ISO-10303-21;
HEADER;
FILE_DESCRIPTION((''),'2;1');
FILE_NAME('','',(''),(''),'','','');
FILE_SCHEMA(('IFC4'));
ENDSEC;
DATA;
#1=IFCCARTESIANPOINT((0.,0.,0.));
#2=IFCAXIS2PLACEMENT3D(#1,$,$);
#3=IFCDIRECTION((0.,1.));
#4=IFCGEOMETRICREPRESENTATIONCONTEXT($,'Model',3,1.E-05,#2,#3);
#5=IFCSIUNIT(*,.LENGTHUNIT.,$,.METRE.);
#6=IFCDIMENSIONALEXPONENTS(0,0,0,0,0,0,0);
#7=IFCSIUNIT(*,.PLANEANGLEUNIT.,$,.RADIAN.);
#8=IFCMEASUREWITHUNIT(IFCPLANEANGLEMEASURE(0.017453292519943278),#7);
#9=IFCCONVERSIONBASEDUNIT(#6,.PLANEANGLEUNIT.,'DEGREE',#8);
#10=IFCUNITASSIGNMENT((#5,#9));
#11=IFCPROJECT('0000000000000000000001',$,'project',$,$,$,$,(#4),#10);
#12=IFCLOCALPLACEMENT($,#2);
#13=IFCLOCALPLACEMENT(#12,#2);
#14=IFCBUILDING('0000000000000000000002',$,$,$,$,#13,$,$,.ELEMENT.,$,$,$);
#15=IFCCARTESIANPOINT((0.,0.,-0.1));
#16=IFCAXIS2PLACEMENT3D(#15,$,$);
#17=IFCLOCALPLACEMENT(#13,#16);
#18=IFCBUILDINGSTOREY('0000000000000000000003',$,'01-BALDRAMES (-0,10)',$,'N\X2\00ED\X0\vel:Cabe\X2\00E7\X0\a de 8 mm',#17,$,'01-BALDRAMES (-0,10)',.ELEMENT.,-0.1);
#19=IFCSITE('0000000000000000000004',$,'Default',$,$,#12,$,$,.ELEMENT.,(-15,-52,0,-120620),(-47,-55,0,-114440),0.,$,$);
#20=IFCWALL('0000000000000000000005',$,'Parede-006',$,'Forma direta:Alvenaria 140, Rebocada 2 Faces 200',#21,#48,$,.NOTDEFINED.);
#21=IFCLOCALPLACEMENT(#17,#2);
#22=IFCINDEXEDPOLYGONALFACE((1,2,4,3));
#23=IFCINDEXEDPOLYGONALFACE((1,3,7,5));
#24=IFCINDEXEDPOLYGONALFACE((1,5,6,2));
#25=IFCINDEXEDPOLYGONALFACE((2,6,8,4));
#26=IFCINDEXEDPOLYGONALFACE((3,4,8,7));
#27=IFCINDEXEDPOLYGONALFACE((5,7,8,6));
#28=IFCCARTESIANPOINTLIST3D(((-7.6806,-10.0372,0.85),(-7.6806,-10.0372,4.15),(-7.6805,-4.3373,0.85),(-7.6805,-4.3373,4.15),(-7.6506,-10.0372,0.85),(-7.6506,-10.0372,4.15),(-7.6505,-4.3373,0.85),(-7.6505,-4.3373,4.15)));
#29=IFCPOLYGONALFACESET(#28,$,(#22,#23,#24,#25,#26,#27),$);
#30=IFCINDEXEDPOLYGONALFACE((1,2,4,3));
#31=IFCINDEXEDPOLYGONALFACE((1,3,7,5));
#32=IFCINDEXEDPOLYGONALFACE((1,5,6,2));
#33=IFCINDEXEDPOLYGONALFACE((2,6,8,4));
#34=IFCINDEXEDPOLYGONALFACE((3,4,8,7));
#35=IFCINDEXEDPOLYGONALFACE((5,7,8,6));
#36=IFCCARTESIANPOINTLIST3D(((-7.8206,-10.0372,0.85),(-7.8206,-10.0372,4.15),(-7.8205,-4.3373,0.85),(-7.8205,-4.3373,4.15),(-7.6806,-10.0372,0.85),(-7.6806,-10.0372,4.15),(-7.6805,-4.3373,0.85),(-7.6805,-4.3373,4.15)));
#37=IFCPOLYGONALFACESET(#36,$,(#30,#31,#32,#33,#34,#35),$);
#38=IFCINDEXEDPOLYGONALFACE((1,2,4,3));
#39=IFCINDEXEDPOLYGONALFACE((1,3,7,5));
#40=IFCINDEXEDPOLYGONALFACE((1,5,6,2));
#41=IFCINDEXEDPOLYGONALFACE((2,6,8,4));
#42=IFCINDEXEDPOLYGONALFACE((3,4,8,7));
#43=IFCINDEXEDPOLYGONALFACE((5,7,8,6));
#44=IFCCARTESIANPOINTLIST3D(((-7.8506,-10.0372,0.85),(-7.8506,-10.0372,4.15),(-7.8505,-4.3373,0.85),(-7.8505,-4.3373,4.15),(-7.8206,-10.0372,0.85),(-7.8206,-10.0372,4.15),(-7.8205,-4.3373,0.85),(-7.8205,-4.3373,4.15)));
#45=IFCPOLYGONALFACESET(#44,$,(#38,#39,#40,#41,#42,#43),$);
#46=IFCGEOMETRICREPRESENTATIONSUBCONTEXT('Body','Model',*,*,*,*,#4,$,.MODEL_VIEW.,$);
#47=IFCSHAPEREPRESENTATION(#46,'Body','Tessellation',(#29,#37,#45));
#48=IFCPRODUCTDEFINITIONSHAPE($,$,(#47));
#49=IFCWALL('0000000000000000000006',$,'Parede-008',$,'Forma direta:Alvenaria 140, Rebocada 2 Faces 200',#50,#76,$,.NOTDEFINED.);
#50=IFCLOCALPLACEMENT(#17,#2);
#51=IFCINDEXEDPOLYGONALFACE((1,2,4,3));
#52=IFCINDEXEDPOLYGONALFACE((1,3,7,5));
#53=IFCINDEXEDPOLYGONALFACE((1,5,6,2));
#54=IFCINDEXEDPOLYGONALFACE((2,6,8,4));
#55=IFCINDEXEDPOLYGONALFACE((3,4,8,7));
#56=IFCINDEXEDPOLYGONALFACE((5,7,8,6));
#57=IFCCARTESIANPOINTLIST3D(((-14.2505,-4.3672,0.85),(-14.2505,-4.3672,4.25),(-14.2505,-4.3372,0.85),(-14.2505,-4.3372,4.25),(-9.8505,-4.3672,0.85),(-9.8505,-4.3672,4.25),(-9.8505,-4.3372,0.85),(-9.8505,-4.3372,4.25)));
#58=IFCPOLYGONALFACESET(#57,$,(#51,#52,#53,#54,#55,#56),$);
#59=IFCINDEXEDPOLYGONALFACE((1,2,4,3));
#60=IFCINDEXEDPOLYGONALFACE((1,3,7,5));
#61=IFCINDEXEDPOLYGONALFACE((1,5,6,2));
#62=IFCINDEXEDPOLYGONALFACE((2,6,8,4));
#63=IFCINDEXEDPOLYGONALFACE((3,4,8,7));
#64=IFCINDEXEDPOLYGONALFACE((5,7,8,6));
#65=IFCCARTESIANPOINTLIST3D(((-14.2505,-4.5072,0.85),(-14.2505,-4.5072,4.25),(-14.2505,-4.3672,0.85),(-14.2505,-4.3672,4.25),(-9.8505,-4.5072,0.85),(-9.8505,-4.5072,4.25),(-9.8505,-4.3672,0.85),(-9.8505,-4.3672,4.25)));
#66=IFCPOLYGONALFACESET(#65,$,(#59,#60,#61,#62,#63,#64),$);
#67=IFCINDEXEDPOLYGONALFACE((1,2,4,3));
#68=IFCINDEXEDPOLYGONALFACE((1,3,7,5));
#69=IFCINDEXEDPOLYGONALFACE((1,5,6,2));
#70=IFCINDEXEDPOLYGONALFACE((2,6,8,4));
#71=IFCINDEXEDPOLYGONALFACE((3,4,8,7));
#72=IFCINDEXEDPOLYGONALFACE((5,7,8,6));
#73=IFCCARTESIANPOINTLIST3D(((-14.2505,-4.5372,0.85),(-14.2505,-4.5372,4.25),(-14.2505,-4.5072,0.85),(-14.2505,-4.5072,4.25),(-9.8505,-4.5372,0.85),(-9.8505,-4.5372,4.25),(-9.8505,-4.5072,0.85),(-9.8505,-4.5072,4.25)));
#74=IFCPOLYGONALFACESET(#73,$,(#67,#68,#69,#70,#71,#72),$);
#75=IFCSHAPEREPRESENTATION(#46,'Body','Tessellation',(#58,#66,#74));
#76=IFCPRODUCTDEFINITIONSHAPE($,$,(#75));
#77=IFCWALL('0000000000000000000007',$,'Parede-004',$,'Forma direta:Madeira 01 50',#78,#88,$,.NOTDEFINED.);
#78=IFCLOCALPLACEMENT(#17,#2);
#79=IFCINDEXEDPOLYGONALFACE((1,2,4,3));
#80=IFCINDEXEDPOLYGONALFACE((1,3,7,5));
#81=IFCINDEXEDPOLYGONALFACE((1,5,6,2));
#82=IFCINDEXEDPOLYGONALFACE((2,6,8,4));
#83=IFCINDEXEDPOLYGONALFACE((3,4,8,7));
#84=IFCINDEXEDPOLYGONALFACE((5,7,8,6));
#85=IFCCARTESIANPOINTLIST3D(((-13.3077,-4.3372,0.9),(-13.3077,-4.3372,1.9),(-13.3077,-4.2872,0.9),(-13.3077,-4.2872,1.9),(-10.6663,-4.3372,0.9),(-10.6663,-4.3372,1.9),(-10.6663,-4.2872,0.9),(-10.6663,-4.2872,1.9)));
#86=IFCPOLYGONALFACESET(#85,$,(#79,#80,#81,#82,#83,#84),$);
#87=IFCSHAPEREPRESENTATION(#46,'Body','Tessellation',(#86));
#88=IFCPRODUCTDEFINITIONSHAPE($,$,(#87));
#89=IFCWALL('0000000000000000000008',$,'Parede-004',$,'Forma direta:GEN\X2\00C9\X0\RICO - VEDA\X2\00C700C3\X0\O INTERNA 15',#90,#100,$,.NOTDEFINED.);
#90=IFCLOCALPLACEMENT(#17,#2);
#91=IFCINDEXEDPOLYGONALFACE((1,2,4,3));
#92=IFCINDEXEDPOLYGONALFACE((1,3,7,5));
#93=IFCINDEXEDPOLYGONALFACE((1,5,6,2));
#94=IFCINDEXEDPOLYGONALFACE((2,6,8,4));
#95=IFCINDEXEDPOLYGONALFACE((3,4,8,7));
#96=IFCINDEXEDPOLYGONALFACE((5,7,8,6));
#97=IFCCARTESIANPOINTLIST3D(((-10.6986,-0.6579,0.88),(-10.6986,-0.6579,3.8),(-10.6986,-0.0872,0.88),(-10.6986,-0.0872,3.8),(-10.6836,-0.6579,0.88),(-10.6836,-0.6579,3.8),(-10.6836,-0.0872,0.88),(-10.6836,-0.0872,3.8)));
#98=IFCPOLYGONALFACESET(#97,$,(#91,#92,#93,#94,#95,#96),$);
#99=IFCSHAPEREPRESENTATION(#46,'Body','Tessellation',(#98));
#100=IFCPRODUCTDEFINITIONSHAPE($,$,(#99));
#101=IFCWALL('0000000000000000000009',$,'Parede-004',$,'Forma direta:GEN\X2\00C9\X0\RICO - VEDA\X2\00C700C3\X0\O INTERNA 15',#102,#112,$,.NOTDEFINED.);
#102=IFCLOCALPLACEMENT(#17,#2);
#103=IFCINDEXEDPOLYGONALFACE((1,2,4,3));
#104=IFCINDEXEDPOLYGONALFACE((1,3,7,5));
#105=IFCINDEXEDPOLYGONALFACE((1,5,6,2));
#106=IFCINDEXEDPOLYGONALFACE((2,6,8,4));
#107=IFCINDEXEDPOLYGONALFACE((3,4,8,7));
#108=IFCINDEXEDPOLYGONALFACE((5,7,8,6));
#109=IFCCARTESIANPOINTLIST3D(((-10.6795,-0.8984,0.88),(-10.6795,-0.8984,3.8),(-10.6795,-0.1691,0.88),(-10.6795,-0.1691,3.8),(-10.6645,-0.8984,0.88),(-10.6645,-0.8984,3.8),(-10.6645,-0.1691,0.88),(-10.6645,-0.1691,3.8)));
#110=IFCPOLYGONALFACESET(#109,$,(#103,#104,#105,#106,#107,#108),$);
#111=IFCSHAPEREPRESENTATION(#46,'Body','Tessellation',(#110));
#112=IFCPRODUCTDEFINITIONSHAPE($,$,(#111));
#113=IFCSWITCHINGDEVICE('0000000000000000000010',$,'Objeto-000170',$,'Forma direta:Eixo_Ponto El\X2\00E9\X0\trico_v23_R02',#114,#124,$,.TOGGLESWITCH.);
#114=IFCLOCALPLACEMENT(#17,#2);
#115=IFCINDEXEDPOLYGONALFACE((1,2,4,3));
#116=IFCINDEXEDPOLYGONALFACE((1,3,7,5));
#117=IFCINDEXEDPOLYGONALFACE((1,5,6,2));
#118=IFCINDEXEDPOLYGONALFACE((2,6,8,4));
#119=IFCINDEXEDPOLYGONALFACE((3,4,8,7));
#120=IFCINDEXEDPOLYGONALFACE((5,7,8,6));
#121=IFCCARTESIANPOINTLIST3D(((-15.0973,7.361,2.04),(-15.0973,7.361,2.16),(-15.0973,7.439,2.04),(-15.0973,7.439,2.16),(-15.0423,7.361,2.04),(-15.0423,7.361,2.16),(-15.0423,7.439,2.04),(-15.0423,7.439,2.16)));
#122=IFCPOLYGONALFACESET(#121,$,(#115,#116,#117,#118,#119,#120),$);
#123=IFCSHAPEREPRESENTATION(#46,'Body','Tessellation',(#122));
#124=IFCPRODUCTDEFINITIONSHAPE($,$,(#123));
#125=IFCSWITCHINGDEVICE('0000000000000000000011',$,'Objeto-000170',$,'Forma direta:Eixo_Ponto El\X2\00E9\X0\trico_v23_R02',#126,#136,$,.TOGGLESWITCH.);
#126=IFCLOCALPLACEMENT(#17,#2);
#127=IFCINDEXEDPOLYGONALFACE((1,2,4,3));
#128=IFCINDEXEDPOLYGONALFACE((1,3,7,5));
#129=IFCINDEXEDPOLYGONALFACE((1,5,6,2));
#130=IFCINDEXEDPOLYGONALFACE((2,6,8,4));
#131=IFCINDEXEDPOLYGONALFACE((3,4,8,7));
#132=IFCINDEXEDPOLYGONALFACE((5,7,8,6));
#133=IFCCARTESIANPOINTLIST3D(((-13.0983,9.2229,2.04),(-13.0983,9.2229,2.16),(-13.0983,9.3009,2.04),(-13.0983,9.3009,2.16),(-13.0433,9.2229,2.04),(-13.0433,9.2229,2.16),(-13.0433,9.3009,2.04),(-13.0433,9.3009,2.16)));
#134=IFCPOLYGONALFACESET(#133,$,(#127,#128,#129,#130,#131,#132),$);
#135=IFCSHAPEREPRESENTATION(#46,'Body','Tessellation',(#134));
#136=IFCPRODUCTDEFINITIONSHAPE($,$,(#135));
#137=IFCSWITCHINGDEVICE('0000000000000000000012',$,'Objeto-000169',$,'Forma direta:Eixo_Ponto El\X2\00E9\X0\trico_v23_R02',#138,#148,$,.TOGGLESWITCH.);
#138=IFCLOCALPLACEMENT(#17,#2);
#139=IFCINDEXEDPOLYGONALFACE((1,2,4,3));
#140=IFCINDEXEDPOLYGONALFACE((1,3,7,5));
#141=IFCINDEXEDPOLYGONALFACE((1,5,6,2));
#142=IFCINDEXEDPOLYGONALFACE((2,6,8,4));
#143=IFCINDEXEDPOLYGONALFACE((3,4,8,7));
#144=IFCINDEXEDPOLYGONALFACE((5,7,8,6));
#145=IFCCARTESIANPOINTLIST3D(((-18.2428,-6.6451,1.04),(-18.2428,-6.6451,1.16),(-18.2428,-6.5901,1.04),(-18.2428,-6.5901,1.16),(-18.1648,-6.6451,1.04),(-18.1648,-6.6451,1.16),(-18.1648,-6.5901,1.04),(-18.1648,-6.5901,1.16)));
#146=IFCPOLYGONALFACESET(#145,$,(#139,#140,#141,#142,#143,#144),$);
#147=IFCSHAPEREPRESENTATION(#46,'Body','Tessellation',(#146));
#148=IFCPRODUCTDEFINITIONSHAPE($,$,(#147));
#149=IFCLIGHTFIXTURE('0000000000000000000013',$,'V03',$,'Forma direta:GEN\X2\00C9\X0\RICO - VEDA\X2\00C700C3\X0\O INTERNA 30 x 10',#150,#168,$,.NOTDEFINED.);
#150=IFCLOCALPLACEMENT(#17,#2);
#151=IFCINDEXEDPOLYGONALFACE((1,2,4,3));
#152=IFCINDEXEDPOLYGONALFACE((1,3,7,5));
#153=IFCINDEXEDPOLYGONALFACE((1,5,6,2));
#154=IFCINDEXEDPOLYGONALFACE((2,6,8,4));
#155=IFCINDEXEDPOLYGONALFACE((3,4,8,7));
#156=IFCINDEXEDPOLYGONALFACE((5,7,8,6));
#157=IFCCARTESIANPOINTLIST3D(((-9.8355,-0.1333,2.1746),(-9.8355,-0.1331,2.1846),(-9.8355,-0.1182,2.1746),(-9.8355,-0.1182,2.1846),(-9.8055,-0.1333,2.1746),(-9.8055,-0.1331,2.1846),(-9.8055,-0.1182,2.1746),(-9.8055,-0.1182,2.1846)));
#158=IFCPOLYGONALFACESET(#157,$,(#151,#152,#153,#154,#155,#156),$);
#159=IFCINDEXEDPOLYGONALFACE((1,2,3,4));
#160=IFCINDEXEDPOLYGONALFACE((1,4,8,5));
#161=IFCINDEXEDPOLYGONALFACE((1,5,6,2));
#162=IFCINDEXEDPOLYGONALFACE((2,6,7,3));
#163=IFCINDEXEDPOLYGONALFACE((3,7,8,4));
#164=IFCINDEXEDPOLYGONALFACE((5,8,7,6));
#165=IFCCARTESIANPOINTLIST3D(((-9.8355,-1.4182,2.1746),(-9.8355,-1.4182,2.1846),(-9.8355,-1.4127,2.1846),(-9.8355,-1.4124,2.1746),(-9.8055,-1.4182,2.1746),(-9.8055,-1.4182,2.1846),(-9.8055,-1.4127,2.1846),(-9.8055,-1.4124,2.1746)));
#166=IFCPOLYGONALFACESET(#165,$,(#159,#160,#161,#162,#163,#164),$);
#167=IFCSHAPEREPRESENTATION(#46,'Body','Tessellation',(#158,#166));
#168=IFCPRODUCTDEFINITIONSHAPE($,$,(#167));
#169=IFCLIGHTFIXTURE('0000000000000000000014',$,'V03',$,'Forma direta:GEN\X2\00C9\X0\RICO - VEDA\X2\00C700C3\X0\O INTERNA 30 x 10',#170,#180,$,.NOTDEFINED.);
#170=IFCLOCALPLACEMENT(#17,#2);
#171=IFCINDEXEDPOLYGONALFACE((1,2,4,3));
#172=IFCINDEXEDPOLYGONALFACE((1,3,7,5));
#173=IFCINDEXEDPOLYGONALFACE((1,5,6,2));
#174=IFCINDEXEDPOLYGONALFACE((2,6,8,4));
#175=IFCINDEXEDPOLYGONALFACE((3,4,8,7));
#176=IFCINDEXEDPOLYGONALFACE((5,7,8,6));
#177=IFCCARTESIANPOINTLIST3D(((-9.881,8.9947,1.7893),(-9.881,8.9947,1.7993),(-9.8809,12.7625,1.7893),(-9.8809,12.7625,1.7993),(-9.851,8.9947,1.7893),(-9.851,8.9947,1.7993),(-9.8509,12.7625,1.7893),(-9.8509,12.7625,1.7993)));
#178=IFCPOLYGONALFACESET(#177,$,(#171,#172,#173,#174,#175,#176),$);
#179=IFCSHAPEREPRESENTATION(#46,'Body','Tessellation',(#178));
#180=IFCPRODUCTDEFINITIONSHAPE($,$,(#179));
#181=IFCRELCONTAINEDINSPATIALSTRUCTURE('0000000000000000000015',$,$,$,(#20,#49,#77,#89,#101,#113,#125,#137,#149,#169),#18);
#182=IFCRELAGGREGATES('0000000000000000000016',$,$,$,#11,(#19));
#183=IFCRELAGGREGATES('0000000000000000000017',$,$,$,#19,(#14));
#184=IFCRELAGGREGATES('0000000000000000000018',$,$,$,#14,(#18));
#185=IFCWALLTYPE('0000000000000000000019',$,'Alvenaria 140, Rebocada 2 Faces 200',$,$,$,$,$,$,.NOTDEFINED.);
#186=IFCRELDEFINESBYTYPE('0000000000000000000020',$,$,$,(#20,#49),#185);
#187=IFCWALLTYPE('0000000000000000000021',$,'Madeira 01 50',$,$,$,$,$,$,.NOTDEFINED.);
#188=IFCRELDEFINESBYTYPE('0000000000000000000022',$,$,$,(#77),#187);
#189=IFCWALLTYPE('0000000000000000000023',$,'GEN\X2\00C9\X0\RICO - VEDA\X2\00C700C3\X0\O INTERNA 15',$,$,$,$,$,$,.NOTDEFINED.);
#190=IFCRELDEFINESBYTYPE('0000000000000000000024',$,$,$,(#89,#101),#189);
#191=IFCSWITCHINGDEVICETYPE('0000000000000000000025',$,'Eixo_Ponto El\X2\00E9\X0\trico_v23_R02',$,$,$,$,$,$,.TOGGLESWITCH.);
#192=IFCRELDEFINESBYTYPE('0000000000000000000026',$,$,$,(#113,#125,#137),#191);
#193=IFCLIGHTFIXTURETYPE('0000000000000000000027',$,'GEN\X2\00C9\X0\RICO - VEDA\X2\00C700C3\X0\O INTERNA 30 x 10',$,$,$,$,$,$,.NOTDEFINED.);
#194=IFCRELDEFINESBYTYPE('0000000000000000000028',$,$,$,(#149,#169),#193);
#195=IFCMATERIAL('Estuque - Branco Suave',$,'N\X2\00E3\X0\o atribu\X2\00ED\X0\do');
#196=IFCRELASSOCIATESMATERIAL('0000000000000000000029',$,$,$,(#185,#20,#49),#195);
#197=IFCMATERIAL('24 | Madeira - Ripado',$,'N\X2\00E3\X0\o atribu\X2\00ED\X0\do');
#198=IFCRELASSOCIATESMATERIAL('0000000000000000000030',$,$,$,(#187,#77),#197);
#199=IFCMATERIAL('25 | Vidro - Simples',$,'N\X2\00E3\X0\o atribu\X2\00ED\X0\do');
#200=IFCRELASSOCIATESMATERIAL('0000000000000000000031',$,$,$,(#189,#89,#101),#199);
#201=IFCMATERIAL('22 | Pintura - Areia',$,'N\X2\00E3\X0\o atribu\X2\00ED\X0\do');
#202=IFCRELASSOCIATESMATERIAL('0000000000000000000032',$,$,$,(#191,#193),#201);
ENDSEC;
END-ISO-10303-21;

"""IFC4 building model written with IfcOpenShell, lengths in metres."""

from ifc_helpers import new_model, entity, si_unit, converted_unit, direction, frame, origin, place, context, subcontext, project, spatial, indexed_curve, outline, extrude, material, type_object, element, save


model = new_model("IFC4")

# Units and contexts
model_context = context("Model", 3, precision=1e-05, world=origin(), true_north=direction((0.0, 1.0)))
body_context = subcontext(model_context, "Body", "Model", "MODEL_VIEW")
ifc_project = project(units=[si_unit("LENGTHUNIT", "METRE"), converted_unit("PLANEANGLEUNIT", "DEGREE", entity("IfcPlaneAngleMeasure", 0.017453292519943278), si_unit("PLANEANGLEUNIT", "RADIAN"), dimensions=[0, 0, 0, 0, 0, 0, 0])], contexts=[model_context])

# Site, building, storey
site_placement = place(None, origin())
site = spatial("IfcSite", under=ifc_project, at=site_placement, Name="Default", CompositionType="ELEMENT", RefLatitude=(-15, -52, 0, -120620), RefLongitude=(-47, -55, 0, -114440), RefElevation=0.0)
building_placement = place(site_placement, origin())
building = spatial("IfcBuilding", under=site, at=building_placement, CompositionType="ELEMENT")
storey_placement = place(building_placement, frame((0.0, 0.0, -0.1)))
storey = spatial("IfcBuildingStorey", under=building, at=storey_placement, Name="01-BALDRAMES (-0,10)", ObjectType="Nível:Cabeça de 8 mm", LongName="01-BALDRAMES (-0,10)", CompositionType="ELEMENT", Elevation=-0.1)

# Shared definitions
ifc_material_1 = material(Name="Estuque - Branco Suave", Category="Não atribuído")
wall_type_1 = type_object("IfcWallType", Name="Alvenaria 140, Rebocada 2 Faces 200", PredefinedType="NOTDEFINED", material=ifc_material_1)

# Walls
wall_1_placement = place(storey_placement, frame((-7.8506, -10.0372, 0.85), z_axis=(0.0, 0.0, 1.0), x_axis=(0.0, 1.0, 0.0)))
element("IfcWall", 1, at=wall_1_placement, inside=storey, type_object=wall_type_1, material=ifc_material_1, Name="Parede-006", ObjectType="Forma direta:Alvenaria 140, Rebocada 2 Faces 200", PredefinedType="NOTDEFINED", context=body_context, shape_type="SweptSolid", body=[
    extrude(outline(indexed_curve([(-0.015, -2.85), (0.015, -2.85), (0.015, 2.85), (-0.015, 2.85), (-0.015, -2.85)], self_intersect=False)), frame((2.85, -0.185, 0.0), z_axis=(0.0, 0.0, 1.0), x_axis=(-0.000011, -1.0, 0.0)), (0.0, 0.0, 1.0), 3.3),
    extrude(outline(indexed_curve([(-0.07, -2.85), (0.07, -2.85), (0.07, 2.85), (-0.07, 2.85), (-0.07, -2.85)], self_intersect=False)), frame((2.85, -0.1, 0.0), z_axis=(0.0, 0.0, 1.0), x_axis=(0.000011, 1.0, 0.0)), (0.0, 0.0, 1.0), 3.3),
    extrude(outline(indexed_curve([(-0.015, -2.85), (0.015, -2.85), (0.015, 2.85), (-0.015, 2.85), (-0.015, -2.85)], self_intersect=False)), frame((2.85, -0.015, 0.0), z_axis=(0.0, 0.0, 1.0), x_axis=(0.000011, 1.0, 0.0)), (0.0, 0.0, 1.0), 3.3),
])
wall_2_placement = place(storey_placement, frame((-14.2505, -4.5372, 0.85)))
element("IfcWall", 2, at=wall_2_placement, inside=storey, type_object=wall_type_1, material=ifc_material_1, Name="Parede-008", ObjectType="Forma direta:Alvenaria 140, Rebocada 2 Faces 200", PredefinedType="NOTDEFINED", context=body_context, shape_type="SweptSolid", body=[
    extrude(outline(indexed_curve([(-0.015, -2.2), (0.015, -2.2), (0.015, 2.2), (-0.015, 2.2), (-0.015, -2.2)], self_intersect=False)), frame((2.2, 0.185, 0.0), z_axis=(0.0, 0.0, 1.0), x_axis=(-0.000007, 1.0, 0.0)), (0.0, 0.0, 1.0), 3.4),
    extrude(outline(indexed_curve([(-0.07, -2.2), (0.07, -2.2), (0.07, 2.2), (-0.07, 2.2), (-0.07, -2.2)], self_intersect=False)), frame((2.2, 0.1, 0.0), z_axis=(0.0, 0.0, 1.0), x_axis=(-0.000013, -1.0, 0.0)), (0.0, 0.0, 1.0), 3.4),
    extrude(outline(indexed_curve([(-0.015, -2.2), (0.015, -2.2), (0.015, 2.2), (-0.015, 2.2), (-0.015, -2.2)], self_intersect=False)), frame((2.2, 0.015, 0.0), z_axis=(0.0, 0.0, 1.0), x_axis=(-0.000013, -1.0, 0.0)), (0.0, 0.0, 1.0), 3.4),
])
ifc_material_2 = material(Name="24 | Madeira - Ripado", Category="Não atribuído")
wall_type_2 = type_object("IfcWallType", Name="Madeira 01 50", PredefinedType="NOTDEFINED", material=ifc_material_2)
wall_3_placement = place(storey_placement, frame((-13.3077, -4.3372, 0.9)))
element("IfcWall", 3, at=wall_3_placement, inside=storey, type_object=wall_type_2, material=ifc_material_2, Name="Parede-004", ObjectType="Forma direta:Madeira 01 50", PredefinedType="NOTDEFINED", context=body_context, shape_type="SweptSolid", body=[
    extrude(outline(indexed_curve([(-0.025, -1.3207), (0.025, -1.3207), (0.025, 1.3207), (-0.025, 1.3207), (-0.025, -1.3207)], self_intersect=False)), frame((1.3207, 0.025, 0.0), z_axis=(0.0, 0.0, 1.0), x_axis=(0.000013, 1.0, 0.0)), (0.0, 0.0, 1.0), 1.0),
])
ifc_material_3 = material(Name="25 | Vidro - Simples", Category="Não atribuído")
wall_type_3 = type_object("IfcWallType", Name="GENÉRICO - VEDAÇÃO INTERNA 15", PredefinedType="NOTDEFINED", material=ifc_material_3)
wall_4_placement = place(storey_placement, frame((-10.6986, -0.6579, 0.88), z_axis=(0.0, 0.0, 1.0), x_axis=(0.0, 1.0, 0.0)))
element("IfcWall", 4, at=wall_4_placement, inside=storey, type_object=wall_type_3, material=ifc_material_3, Name="Parede-004", ObjectType="Forma direta:GENÉRICO - VEDAÇÃO INTERNA 15", PredefinedType="NOTDEFINED", context=body_context, shape_type="SweptSolid", body=[
    extrude(outline(indexed_curve([(-0.0075, -0.2854), (0.0075, -0.2854), (0.0075, 0.2854), (-0.0075, 0.2854), (-0.0075, -0.2854)], self_intersect=False)), frame((0.2854, -0.0075, 0.0), z_axis=(0.0, 0.0, 1.0), x_axis=(0.000025, -1.0, 0.0)), (0.0, 0.0, 1.0), 2.92),
])
wall_5_placement = place(storey_placement, frame((-10.6795, -0.8984, 0.88), z_axis=(0.0, 0.0, 1.0), x_axis=(0.0, 1.0, 0.0)))
element("IfcWall", 5, at=wall_5_placement, inside=storey, type_object=wall_type_3, material=ifc_material_3, Name="Parede-004", ObjectType="Forma direta:GENÉRICO - VEDAÇÃO INTERNA 15", PredefinedType="NOTDEFINED", context=body_context, shape_type="SweptSolid", body=[
    extrude(outline(indexed_curve([(-0.0075, -0.3647), (0.0075, -0.3647), (0.0075, 0.3647), (-0.0075, 0.3647), (-0.0075, -0.3647)], self_intersect=False)), frame((0.3647, -0.0075, 0.0), z_axis=(0.0, 0.0, 1.0), x_axis=(0.000025, -1.0, 0.0)), (0.0, 0.0, 1.0), 2.92),
])

# Switching devices
ifc_material_4 = material(Name="22 | Pintura - Areia", Category="Não atribuído")
switching_device_type = type_object("IfcSwitchingDeviceType", Name="Eixo_Ponto Elétrico_v23_R02", PredefinedType="TOGGLESWITCH", material=ifc_material_4)
switching_device_1_placement = place(storey_placement, origin())
element("IfcSwitchingDevice", 6, at=switching_device_1_placement, inside=storey, type_object=switching_device_type, Name="Objeto-000170", ObjectType="Forma direta:Eixo_Ponto Elétrico_v23_R02", PredefinedType="TOGGLESWITCH", context=body_context, shape_type="SweptSolid", body=[
    extrude(outline(indexed_curve([(-0.0275, -0.039), (0.0275, -0.039), (0.0275, 0.039), (-0.0275, 0.039), (-0.0275, -0.039)], self_intersect=False)), frame((-15.0698, 7.4, 2.04), z_axis=(0.0, 0.0, 1.0), x_axis=(-1.0, 0.000013, 0.0)), (0.0, 0.0, 1.0), 0.12),
])
switching_device_2_placement = place(storey_placement, origin())
element("IfcSwitchingDevice", 7, at=switching_device_2_placement, inside=storey, type_object=switching_device_type, Name="Objeto-000170", ObjectType="Forma direta:Eixo_Ponto Elétrico_v23_R02", PredefinedType="TOGGLESWITCH", context=body_context, shape_type="SweptSolid", body=[
    extrude(outline(indexed_curve([(-0.0275, -0.039), (0.0275, -0.039), (0.0275, 0.039), (-0.0275, 0.039), (-0.0275, -0.039)], self_intersect=False)), frame((-13.0708, 9.2619, 2.04), z_axis=(0.0, 0.0, 1.0), x_axis=(-1.0, 0.000013, 0.0)), (0.0, 0.0, 1.0), 0.12),
])
switching_device_3_placement = place(storey_placement, origin())
element("IfcSwitchingDevice", 8, at=switching_device_3_placement, inside=storey, type_object=switching_device_type, Name="Objeto-000169", ObjectType="Forma direta:Eixo_Ponto Elétrico_v23_R02", PredefinedType="TOGGLESWITCH", context=body_context, shape_type="SweptSolid", body=[
    extrude(outline(indexed_curve([(-0.0275, -0.039), (0.0275, -0.039), (0.0275, 0.039), (-0.0275, 0.039), (-0.0275, -0.039)], self_intersect=False)), frame((-18.2038, -6.6176, 1.04), z_axis=(0.0, 0.0, 1.0), x_axis=(0.000013, 1.0, 0.0)), (0.0, 0.0, 1.0), 0.12),
])

# Light fixtures
light_fixture_type_1 = type_object("IfcLightFixtureType", Name="GENÉRICO - VEDAÇÃO INTERNA 30 x 10", PredefinedType="NOTDEFINED", material=ifc_material_4)
light_fixture_1_placement = place(storey_placement, origin())
element("IfcLightFixture", 9, at=light_fixture_1_placement, inside=storey, type_object=light_fixture_type_1, Name="V03", ObjectType="Forma direta:GENÉRICO - VEDAÇÃO INTERNA 30 x 10", PredefinedType="NOTDEFINED", context=body_context, shape_type="SweptSolid", body=[
    extrude(outline(indexed_curve([(-0.0076, -0.005), (0.0075, -0.005), (0.0075, 0.005), (-0.0075, 0.005), (-0.0076, -0.005)], self_intersect=False)), frame((-9.8355, -0.1257, 2.1796), z_axis=(1.0, 0.000006, 0.0), x_axis=(-0.000006, 1.0, 0.0)), (0.0, 0.0, 1.0), 0.03),
    extrude(outline(indexed_curve([(-0.0026, -0.005), (0.0028, -0.005), (0.0028, 0.005), (-0.003, 0.005), (-0.0026, -0.005)], self_intersect=False)), frame((-9.8355, -1.4154, 2.1796), z_axis=(1.0, 0.000006, 0.0), x_axis=(0.000006, -1.0, 0.0)), (0.0, 0.0, 1.0), 0.03),
])
light_fixture_2_placement = place(storey_placement, origin())
element("IfcLightFixture", 10, at=light_fixture_2_placement, inside=storey, type_object=light_fixture_type_1, Name="V03", ObjectType="Forma direta:GENÉRICO - VEDAÇÃO INTERNA 30 x 10", PredefinedType="NOTDEFINED", context=body_context, shape_type="SweptSolid", body=[
    extrude(outline(indexed_curve([(-1.8839, -0.015), (1.8839, -0.015), (1.8839, 0.015), (-1.8839, 0.015), (-1.8839, -0.015)], self_intersect=False)), frame((-9.866, 10.8786, 1.7893), z_axis=(0.0, 0.0, 1.0), x_axis=(-0.000013, -1.0, 0.0)), (0.0, 0.0, 1.0), 0.01),
])

save(model, "model.ifc")
